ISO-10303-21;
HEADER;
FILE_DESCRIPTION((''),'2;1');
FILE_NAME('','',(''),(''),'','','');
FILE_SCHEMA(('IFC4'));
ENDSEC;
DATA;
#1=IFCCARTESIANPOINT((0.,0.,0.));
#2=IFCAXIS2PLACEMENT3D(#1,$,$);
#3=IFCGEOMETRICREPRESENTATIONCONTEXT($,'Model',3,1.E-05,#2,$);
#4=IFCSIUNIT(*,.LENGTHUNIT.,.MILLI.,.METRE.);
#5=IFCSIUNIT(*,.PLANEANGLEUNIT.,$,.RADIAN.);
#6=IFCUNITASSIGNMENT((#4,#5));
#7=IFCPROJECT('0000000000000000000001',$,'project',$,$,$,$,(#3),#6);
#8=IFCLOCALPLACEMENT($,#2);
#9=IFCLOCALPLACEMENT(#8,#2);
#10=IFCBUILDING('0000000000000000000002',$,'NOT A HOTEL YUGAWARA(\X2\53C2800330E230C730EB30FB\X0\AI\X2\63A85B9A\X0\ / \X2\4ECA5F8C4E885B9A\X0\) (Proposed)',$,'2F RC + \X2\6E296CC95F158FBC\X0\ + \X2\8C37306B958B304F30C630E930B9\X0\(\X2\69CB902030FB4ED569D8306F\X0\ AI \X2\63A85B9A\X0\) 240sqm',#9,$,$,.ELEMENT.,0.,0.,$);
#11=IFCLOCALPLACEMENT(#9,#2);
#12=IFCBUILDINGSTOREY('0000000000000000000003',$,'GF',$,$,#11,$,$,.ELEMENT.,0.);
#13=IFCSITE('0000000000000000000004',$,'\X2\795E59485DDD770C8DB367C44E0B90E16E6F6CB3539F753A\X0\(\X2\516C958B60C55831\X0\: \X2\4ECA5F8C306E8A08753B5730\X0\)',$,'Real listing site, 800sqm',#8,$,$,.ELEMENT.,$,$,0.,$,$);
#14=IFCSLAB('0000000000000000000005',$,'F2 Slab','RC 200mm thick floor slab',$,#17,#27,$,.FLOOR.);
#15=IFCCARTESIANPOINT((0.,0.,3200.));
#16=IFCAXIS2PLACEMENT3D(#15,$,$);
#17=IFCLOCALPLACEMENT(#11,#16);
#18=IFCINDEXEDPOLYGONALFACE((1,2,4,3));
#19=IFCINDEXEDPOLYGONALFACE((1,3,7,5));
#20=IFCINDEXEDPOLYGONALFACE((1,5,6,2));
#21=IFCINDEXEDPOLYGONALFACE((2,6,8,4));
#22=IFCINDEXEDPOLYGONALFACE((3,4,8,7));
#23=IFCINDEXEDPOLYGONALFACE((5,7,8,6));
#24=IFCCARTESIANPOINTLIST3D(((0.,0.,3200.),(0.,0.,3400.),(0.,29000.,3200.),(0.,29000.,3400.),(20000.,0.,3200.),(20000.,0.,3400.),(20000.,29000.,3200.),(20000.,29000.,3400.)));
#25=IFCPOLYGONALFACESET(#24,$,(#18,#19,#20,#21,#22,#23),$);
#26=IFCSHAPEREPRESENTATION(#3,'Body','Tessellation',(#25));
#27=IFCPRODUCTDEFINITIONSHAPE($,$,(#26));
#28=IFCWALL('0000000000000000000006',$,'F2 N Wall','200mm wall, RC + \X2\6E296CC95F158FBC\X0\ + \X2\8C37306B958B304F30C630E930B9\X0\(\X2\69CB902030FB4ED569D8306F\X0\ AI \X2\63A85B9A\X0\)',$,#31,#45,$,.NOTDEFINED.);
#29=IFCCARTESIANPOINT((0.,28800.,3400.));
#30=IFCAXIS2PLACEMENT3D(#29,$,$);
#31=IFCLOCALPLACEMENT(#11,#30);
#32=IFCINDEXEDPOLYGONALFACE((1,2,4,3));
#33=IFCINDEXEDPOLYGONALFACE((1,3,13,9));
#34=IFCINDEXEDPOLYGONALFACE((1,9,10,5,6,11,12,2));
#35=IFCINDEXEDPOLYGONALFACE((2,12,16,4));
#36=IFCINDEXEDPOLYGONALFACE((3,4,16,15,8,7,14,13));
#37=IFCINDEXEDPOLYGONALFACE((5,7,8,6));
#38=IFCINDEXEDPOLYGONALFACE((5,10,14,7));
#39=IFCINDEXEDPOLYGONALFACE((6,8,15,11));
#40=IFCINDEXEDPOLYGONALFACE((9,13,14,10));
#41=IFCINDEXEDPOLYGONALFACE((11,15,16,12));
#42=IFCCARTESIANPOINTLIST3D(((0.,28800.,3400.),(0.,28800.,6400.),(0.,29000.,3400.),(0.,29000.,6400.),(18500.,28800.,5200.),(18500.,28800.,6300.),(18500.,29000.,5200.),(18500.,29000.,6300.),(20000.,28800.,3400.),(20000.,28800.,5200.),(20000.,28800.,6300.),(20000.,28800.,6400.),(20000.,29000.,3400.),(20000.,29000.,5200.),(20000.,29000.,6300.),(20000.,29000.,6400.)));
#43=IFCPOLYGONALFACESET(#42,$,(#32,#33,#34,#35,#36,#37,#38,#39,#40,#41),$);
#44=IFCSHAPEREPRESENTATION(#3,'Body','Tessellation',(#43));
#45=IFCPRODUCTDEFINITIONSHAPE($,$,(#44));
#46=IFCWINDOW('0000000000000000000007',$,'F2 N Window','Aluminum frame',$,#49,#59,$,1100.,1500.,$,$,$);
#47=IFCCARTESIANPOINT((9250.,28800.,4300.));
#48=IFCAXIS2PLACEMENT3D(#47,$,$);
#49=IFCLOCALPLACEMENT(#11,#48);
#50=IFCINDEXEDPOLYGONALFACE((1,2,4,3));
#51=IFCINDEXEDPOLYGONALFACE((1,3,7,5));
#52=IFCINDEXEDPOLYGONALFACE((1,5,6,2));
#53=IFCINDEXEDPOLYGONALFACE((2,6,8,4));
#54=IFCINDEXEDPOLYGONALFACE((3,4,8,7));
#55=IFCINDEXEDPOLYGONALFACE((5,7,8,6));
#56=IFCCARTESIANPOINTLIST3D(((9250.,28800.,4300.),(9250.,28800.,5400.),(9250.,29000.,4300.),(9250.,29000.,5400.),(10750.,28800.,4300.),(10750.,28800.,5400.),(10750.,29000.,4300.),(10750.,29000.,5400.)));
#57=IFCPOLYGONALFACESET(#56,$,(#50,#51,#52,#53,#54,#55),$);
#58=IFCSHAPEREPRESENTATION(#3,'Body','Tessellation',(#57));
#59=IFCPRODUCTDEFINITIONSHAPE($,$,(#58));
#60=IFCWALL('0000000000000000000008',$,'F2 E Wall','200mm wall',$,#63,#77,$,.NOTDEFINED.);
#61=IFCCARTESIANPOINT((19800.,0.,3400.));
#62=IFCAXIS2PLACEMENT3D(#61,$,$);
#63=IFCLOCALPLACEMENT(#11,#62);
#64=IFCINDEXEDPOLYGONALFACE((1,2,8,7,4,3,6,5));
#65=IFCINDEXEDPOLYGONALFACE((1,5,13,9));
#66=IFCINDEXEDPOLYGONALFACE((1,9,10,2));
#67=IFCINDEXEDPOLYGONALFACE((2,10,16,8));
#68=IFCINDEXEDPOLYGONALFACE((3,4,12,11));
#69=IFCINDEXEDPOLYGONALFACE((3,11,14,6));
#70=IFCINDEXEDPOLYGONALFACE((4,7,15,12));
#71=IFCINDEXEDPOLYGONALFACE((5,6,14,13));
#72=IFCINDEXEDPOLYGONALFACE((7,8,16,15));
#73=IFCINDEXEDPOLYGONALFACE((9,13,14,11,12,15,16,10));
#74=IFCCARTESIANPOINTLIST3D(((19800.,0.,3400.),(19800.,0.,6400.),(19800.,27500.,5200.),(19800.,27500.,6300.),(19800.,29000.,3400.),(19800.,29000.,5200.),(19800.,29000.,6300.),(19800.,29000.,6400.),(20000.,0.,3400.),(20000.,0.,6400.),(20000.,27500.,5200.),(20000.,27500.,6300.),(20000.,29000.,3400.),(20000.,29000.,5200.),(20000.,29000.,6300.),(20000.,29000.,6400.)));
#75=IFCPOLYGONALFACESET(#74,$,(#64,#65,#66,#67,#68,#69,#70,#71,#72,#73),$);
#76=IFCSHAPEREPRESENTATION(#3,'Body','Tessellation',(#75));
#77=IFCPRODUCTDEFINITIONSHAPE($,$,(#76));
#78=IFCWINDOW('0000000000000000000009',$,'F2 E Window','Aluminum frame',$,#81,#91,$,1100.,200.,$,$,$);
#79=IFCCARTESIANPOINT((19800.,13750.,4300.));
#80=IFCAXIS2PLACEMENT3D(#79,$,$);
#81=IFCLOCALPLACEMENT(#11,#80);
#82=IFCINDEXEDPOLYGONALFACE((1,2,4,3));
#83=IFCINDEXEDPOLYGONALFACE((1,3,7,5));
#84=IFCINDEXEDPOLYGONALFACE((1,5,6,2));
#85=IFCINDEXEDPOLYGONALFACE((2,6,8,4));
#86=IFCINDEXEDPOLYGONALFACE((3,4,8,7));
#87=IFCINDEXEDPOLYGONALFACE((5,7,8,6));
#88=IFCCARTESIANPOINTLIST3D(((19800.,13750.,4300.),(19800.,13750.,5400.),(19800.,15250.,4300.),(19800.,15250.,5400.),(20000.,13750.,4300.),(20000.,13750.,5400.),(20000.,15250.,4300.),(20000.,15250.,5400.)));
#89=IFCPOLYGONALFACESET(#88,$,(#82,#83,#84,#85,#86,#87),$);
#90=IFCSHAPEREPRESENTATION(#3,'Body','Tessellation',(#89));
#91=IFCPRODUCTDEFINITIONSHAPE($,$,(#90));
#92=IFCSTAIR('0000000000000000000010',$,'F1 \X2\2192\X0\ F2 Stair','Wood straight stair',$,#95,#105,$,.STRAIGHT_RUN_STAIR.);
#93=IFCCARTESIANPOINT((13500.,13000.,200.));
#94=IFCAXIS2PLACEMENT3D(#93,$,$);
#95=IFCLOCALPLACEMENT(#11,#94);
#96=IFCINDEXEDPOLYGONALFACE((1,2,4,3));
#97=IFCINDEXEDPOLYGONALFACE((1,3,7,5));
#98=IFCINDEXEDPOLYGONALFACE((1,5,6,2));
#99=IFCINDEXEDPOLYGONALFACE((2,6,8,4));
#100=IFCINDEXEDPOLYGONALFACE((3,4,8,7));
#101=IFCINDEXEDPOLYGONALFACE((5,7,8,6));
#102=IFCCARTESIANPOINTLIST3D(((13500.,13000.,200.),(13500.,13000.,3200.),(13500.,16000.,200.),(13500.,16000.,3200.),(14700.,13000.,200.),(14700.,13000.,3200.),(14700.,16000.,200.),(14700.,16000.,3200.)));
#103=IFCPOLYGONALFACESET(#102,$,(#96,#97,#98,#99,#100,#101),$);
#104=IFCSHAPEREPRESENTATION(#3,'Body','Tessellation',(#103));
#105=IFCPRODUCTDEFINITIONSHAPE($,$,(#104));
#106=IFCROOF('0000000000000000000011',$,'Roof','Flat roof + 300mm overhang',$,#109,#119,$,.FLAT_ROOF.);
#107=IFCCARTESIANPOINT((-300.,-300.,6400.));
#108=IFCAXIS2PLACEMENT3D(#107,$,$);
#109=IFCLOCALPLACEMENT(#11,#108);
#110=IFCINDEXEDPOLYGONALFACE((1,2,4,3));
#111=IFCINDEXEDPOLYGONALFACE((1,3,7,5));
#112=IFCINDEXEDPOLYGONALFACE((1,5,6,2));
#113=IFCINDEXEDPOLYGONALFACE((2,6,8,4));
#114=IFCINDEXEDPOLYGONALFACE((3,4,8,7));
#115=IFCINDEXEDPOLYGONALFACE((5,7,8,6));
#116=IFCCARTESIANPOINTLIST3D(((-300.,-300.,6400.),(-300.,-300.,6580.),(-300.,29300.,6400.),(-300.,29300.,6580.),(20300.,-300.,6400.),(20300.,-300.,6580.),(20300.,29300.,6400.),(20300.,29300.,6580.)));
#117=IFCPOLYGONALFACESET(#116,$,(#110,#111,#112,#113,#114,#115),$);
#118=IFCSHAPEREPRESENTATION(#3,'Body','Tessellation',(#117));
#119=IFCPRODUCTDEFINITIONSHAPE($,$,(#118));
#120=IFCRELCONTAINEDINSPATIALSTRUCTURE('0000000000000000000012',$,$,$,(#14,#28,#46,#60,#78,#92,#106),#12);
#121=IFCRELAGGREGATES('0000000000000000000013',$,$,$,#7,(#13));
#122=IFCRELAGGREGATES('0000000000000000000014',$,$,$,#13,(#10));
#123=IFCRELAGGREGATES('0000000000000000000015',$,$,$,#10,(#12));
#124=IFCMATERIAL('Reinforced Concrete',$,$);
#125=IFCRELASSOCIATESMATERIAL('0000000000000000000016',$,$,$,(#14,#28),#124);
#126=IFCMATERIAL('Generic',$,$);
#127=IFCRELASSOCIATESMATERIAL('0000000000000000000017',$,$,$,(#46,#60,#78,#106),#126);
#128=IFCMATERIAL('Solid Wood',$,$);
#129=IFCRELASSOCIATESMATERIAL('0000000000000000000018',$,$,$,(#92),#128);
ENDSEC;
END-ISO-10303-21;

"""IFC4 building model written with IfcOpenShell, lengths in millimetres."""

from ifc_helpers import new_model, si_unit, frame, frame_2d, origin, place, context, project, spatial, rectangle, extrude, material, element, fill, save


model = new_model("IFC4")

# Units and contexts
model_context = context("Model", 3, precision=1e-05, world=origin())
ifc_project = project(units=[si_unit("LENGTHUNIT", "METRE", prefix="MILLI"), si_unit("PLANEANGLEUNIT", "RADIAN")], contexts=[model_context])

# Site, building, storey
site_placement = place(None, origin())
site = spatial("IfcSite", under=ifc_project, at=site_placement, Name="神奈川県足柄下郡湯河原町(公開情報: 今後の計画地)", ObjectType="Real listing site, 800sqm", CompositionType="ELEMENT", RefElevation=0.0)
building_placement = place(site_placement, origin())
building = spatial("IfcBuilding", under=site, at=building_placement, Name="NOT A HOTEL YUGAWARA(参考モデル・AI推定 / 今後予定) (Proposed)", ObjectType="2F RC + 温泉引込 + 谷に開くテラス(構造・仕様は AI 推定) 240sqm", CompositionType="ELEMENT", ElevationOfRefHeight=0.0, ElevationOfTerrain=0.0)
storey_placement = place(building_placement, origin())
storey = spatial("IfcBuildingStorey", under=building, at=storey_placement, Name="GF", CompositionType="ELEMENT", Elevation=0.0)

# Slab
ifc_material_1 = material(Name="Reinforced Concrete")
slab_1_placement = place(storey_placement, frame((0.0, 0.0, 3200.0)))
element("IfcSlab", 1, at=slab_1_placement, inside=storey, material=ifc_material_1, Name="F2 Slab", Description="RC 200mm thick floor slab", PredefinedType="FLOOR", context=model_context, shape_type="SweptSolid", body=[
    extrude(rectangle(XDim=20000.0, YDim=29000.0, at=frame_2d((10000.0, 14500.0))), frame((0.0, 0.0, 3200.0)), (0.0, 0.0, 1.0), 200.0),
])

# Shared definitions
ifc_material_2 = material(Name="Generic")

# Shared definitions
ifc_material_3 = material(Name="Solid Wood")

# Walls, openings, windows
wall_1_placement = place(storey_placement, frame((0.0, 28800.0, 3400.0)))
wall_1 = element("IfcWall", 2, at=wall_1_placement, inside=storey, material=ifc_material_1, Name="F2 N Wall", Description="200mm wall, RC + 温泉引込 + 谷に開くテラス(構造・仕様は AI 推定)", PredefinedType="NOTDEFINED", context=model_context, shape_type="SweptSolid", body=[
    extrude(rectangle(XDim=20000.0, YDim=200.0, at=frame_2d((10000.0, 100.0))), frame((0.0, 28800.0, 3400.0)), (0.0, 0.0, 1.0), 3000.0),
])
opening_1_placement = place(storey_placement, frame((9250.0, 28800.0, 4300.0)))
opening_1 = element("IfcOpeningElement", 3, at=opening_1_placement, cuts=wall_1, PredefinedType="NOTDEFINED", context=model_context, shape_type="SweptSolid", body=[
    extrude(rectangle(XDim=1500.0, YDim=200.0, at=frame_2d((750.0, 100.0))), frame((9250.0, 28800.0, 4300.0)), (0.0, 0.0, 1.0), 1100.0),
])
window_1_placement = place(storey_placement, frame((9250.0, 28800.0, 4300.0)))
window_1 = element("IfcWindow", 4, at=window_1_placement, inside=storey, material=ifc_material_2, Name="F2 N Window", Description="Aluminum frame", OverallHeight=1100.0, OverallWidth=1500.0, context=model_context, shape_type="SweptSolid", body=[
    extrude(rectangle(XDim=1500.0, YDim=200.0, at=frame_2d((750.0, 100.0))), frame((9250.0, 28800.0, 4300.0)), (0.0, 0.0, 1.0), 1100.0),
])
fill(opening_1, window_1)
wall_2_placement = place(storey_placement, frame((19800.0, 0.0, 3400.0)))
wall_2 = element("IfcWall", 5, at=wall_2_placement, inside=storey, material=ifc_material_2, Name="F2 E Wall", Description="200mm wall", PredefinedType="NOTDEFINED", context=model_context, shape_type="SweptSolid", body=[
    extrude(rectangle(XDim=200.0, YDim=29000.0, at=frame_2d((100.0, 14500.0))), frame((19800.0, 0.0, 3400.0)), (0.0, 0.0, 1.0), 3000.0),
])
opening_2_placement = place(storey_placement, frame((19800.0, 13750.0, 4300.0)))
opening_2 = element("IfcOpeningElement", 6, at=opening_2_placement, cuts=wall_2, PredefinedType="NOTDEFINED", context=model_context, shape_type="SweptSolid", body=[
    extrude(rectangle(XDim=200.0, YDim=1500.0, at=frame_2d((100.0, 750.0))), frame((19800.0, 13750.0, 4300.0)), (0.0, 0.0, 1.0), 1100.0),
])
window_2_placement = place(storey_placement, frame((19800.0, 13750.0, 4300.0)))
window_2 = element("IfcWindow", 7, at=window_2_placement, inside=storey, material=ifc_material_2, Name="F2 E Window", Description="Aluminum frame", OverallHeight=1100.0, OverallWidth=200.0, context=model_context, shape_type="SweptSolid", body=[
    extrude(rectangle(XDim=200.0, YDim=1500.0, at=frame_2d((100.0, 750.0))), frame((19800.0, 13750.0, 4300.0)), (0.0, 0.0, 1.0), 1100.0),
])
fill(opening_2, window_2)

# Stair
stair_placement = place(storey_placement, frame((13500.0, 13000.0, 200.0)))
element("IfcStair", 8, at=stair_placement, inside=storey, material=ifc_material_3, Name="F1 → F2 Stair", Description="Wood straight stair", PredefinedType="STRAIGHT_RUN_STAIR", context=model_context, shape_type="SweptSolid", body=[
    extrude(rectangle(XDim=1200.0, YDim=3000.0, at=frame_2d((600.0, 1500.0))), frame((13500.0, 13000.0, 200.0)), (0.0, 0.0, 1.0), 3000.0),
])

# Roof
roof_placement = place(storey_placement, frame((-300.0, -300.0, 6400.0)))
element("IfcRoof", 9, at=roof_placement, inside=storey, material=ifc_material_2, Name="Roof", Description="Flat roof + 300mm overhang", PredefinedType="FLAT_ROOF", context=model_context, shape_type="SweptSolid", body=[
    extrude(rectangle(XDim=20600.0, YDim=29600.0, at=frame_2d((10300.0, 14800.0))), frame((-300.0, -300.0, 6400.0)), (0.0, 0.0, 1.0), 180.0),
])

save(model, "model.ifc")
